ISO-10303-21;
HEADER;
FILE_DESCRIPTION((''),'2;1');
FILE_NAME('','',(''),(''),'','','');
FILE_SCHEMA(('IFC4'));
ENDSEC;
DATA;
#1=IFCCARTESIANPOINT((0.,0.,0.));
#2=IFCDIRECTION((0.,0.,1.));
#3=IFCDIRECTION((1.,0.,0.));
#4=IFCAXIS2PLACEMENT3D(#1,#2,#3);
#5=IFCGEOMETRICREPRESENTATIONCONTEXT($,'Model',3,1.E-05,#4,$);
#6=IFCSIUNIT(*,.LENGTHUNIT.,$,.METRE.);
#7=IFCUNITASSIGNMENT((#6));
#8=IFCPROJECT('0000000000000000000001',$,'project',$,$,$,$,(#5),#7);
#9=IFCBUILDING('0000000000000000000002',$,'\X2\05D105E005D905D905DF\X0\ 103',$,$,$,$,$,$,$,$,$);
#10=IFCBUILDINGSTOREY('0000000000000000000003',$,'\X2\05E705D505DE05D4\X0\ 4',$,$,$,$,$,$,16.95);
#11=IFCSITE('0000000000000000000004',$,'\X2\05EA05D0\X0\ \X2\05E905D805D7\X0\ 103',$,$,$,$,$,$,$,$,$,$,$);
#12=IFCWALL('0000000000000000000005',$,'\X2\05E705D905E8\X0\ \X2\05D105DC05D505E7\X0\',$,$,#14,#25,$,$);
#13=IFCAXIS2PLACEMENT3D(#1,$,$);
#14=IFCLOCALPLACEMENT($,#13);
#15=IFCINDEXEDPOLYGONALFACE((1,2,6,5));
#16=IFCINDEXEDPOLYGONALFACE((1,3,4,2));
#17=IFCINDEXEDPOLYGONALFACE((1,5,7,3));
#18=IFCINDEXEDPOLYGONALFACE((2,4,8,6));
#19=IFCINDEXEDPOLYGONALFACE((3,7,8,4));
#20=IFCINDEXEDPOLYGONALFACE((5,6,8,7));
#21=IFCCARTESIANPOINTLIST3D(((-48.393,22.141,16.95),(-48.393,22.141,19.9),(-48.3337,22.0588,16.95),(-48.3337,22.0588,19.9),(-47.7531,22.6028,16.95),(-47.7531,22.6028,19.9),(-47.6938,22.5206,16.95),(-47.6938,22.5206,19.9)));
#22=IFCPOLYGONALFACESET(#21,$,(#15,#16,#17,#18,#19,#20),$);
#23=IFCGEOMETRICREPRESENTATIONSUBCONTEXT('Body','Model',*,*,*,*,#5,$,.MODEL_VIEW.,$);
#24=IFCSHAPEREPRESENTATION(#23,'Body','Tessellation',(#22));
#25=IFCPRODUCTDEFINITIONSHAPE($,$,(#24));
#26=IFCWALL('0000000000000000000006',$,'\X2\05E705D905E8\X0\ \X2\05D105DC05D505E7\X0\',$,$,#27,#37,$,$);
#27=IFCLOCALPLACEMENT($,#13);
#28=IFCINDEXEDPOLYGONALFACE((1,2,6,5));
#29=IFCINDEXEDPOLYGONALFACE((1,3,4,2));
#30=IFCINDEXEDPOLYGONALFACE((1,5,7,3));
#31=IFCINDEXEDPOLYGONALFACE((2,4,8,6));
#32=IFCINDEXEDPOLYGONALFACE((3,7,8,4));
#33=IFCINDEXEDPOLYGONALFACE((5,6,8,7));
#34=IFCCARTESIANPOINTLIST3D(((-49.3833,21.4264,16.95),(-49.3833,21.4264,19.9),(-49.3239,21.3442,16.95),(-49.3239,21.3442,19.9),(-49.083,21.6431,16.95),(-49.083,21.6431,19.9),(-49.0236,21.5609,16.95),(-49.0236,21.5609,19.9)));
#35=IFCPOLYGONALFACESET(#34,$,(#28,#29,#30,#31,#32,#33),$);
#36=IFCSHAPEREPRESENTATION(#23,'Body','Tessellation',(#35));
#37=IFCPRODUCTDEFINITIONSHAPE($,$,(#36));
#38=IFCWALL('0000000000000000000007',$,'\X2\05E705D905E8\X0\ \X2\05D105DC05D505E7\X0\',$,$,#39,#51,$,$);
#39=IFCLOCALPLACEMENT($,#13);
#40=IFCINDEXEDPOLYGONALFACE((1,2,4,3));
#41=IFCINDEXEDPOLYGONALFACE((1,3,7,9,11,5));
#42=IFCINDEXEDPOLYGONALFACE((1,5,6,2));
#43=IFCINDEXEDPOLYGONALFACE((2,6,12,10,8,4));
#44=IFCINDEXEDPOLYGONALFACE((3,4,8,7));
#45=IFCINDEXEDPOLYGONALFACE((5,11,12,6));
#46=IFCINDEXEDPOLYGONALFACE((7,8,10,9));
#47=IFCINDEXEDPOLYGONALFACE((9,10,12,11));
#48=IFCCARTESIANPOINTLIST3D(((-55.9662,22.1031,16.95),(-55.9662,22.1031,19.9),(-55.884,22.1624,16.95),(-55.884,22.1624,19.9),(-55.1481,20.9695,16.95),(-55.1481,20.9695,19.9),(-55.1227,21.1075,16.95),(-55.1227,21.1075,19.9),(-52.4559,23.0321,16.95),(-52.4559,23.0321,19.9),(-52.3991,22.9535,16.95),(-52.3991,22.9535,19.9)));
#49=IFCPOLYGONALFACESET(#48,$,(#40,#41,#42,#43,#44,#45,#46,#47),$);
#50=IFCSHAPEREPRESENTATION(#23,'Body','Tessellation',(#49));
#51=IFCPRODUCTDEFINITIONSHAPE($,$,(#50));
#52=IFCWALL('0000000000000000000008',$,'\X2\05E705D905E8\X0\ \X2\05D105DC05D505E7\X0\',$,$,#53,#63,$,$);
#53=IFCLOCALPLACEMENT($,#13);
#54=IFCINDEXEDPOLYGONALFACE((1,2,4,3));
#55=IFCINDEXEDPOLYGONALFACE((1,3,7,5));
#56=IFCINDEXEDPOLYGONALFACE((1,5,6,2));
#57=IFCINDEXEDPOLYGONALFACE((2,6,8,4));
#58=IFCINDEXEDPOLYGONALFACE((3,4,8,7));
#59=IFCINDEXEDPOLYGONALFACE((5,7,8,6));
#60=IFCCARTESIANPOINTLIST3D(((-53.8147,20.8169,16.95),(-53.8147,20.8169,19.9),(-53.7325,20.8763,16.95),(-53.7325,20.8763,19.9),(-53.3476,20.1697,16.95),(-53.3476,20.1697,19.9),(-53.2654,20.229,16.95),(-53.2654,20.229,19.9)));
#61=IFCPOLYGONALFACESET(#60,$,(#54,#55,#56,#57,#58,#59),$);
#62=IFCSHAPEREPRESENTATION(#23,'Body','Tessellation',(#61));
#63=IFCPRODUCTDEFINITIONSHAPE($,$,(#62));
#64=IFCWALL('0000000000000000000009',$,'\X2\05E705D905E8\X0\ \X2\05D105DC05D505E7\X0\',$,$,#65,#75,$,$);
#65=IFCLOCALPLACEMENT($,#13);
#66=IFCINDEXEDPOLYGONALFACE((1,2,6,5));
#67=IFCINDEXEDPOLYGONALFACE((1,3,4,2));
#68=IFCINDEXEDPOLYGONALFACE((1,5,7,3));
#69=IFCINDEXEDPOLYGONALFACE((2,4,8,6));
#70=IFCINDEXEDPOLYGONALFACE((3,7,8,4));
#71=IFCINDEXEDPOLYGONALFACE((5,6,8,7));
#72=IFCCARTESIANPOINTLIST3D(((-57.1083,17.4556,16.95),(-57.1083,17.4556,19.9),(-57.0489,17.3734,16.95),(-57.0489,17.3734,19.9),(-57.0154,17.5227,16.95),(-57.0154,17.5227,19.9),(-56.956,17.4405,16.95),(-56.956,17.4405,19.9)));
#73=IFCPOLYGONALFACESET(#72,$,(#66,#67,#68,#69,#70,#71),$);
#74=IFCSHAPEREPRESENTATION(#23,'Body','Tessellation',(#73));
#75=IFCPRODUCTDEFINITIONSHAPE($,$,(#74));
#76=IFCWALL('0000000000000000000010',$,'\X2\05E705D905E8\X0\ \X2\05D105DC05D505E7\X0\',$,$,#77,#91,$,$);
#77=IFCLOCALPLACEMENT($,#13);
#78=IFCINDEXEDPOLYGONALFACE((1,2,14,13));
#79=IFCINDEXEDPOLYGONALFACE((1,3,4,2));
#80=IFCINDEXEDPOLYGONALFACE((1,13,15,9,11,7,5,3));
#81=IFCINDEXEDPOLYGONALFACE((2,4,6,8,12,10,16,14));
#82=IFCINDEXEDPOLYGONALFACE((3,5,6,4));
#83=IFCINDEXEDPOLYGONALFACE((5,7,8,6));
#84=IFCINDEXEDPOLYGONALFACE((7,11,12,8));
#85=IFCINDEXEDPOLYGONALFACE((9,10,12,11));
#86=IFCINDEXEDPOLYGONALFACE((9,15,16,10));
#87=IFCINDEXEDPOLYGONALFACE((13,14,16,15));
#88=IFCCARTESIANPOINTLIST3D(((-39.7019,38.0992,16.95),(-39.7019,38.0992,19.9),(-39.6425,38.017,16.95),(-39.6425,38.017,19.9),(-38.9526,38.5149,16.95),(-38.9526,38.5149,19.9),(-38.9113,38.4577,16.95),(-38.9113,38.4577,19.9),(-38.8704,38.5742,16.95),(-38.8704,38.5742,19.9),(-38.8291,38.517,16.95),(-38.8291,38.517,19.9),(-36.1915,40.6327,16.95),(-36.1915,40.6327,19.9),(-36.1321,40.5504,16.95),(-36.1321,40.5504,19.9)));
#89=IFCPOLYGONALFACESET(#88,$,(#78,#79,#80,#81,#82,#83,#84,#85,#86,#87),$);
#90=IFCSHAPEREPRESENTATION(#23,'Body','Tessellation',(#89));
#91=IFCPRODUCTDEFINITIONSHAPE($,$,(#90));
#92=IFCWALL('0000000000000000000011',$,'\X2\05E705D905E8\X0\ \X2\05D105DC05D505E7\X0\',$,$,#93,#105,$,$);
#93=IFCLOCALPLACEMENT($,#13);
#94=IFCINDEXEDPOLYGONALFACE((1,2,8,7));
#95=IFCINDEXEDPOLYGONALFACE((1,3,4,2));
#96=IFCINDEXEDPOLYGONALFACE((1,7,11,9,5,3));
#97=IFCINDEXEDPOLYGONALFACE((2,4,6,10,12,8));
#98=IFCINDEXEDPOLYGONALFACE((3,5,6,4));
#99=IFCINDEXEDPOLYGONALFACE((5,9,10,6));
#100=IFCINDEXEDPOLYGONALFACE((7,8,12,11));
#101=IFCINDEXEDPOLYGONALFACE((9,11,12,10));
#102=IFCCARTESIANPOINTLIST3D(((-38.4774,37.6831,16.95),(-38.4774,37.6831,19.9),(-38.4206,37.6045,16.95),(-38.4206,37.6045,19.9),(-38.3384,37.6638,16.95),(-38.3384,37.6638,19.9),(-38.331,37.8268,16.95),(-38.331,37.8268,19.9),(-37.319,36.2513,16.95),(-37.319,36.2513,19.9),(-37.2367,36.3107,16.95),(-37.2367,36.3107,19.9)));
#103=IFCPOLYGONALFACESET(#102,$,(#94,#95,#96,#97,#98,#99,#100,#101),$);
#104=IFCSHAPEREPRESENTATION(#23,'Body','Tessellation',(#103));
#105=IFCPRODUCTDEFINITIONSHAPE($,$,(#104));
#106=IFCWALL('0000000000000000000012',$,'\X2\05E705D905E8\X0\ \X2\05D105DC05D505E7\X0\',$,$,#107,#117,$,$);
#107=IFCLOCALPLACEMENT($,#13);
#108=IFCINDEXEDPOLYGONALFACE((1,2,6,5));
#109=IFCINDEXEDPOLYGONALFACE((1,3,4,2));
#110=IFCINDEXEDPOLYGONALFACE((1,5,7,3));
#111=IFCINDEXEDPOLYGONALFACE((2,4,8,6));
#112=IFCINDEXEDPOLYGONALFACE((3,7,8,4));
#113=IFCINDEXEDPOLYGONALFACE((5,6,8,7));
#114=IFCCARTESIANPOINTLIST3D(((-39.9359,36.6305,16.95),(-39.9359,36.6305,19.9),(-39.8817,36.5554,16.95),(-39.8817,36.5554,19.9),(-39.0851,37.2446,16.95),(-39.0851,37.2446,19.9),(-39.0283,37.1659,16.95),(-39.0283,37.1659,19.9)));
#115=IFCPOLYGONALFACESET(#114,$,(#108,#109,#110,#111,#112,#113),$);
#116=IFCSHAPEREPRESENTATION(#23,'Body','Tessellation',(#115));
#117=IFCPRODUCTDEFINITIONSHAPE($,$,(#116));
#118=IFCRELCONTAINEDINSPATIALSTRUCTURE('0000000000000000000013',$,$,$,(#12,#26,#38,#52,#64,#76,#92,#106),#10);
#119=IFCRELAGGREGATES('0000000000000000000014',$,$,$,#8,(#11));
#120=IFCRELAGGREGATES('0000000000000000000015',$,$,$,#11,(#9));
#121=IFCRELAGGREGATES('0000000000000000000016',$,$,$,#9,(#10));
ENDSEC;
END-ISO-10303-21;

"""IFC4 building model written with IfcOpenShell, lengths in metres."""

from ifc_helpers import new_model, si_unit, frame, origin_with_axes, context, subcontext, project, spatial, polyline, outline, extrude, element, save


model = new_model("IFC4")

# Units and contexts
model_context = context("Model", 3, precision=1e-05, world=origin_with_axes())
body_context = subcontext(model_context, "Body", "Model", "MODEL_VIEW")
ifc_project = project(units=[si_unit("LENGTHUNIT", "METRE")], contexts=[model_context])

# Site, building, storey
site = spatial("IfcSite", under=ifc_project, Name="תא שטח 103")
building = spatial("IfcBuilding", under=site, Name="בניין 103")
storey = spatial("IfcBuildingStorey", under=building, Name="קומה 4", Elevation=16.95)

# Walls
element("IfcWall", 1, inside=storey, Name="קיר בלוק", context=body_context, shape_type="SweptSolid", body=[
    extrude(outline(polyline([(-48.3337, 22.0588), (-48.393, 22.141), (-47.7531, 22.6028), (-47.6938, 22.5206), (-48.3337, 22.0588)])), frame((0.0, 0.0, 16.95)), (0.0, 0.0, 1.0), 2.95),
])
element("IfcWall", 2, inside=storey, Name="קיר בלוק", context=body_context, shape_type="SweptSolid", body=[
    extrude(outline(polyline([(-49.3239, 21.3442), (-49.3833, 21.4264), (-49.083, 21.6431), (-49.0236, 21.5609), (-49.3239, 21.3442)])), frame((0.0, 0.0, 16.95)), (0.0, 0.0, 1.0), 2.95),
])
element("IfcWall", 3, inside=storey, Name="קיר בלוק", context=body_context, shape_type="SweptSolid", body=[
    extrude(outline(polyline([(-55.1227, 21.1075), (-52.4559, 23.0321), (-52.3991, 22.9535), (-55.1481, 20.9695), (-55.9662, 22.1031), (-55.884, 22.1624), (-55.1227, 21.1075)])), frame((0.0, 0.0, 16.95)), (0.0, 0.0, 1.0), 2.95),
])
element("IfcWall", 4, inside=storey, Name="קיר בלוק", context=body_context, shape_type="SweptSolid", body=[
    extrude(outline(polyline([(-53.8147, 20.8169), (-53.7325, 20.8763), (-53.2654, 20.229), (-53.3476, 20.1697), (-53.8147, 20.8169)])), frame((0.0, 0.0, 16.95)), (0.0, 0.0, 1.0), 2.95),
])
element("IfcWall", 5, inside=storey, Name="קיר בלוק", context=body_context, shape_type="SweptSolid", body=[
    extrude(outline(polyline([(-57.0154, 17.5227), (-56.956, 17.4405), (-57.0489, 17.3734), (-57.1083, 17.4556), (-57.0154, 17.5227)])), frame((0.0, 0.0, 16.95)), (0.0, 0.0, 1.0), 2.95),
])
element("IfcWall", 6, inside=storey, Name="קיר בלוק", context=body_context, shape_type="SweptSolid", body=[
    extrude(outline(polyline([(-39.6425, 38.017), (-39.7019, 38.0992), (-36.1915, 40.6327), (-36.1321, 40.5504), (-38.8704, 38.5742), (-38.8291, 38.517), (-38.9113, 38.4577), (-38.9526, 38.5149), (-39.6425, 38.017)])), frame((0.0, 0.0, 16.95)), (0.0, 0.0, 1.0), 2.95),
])
element("IfcWall", 7, inside=storey, Name="קיר בלוק", context=body_context, shape_type="SweptSolid", body=[
    extrude(outline(polyline([(-38.4206, 37.6045), (-38.4774, 37.6831), (-38.331, 37.8268), (-37.2367, 36.3107), (-37.319, 36.2513), (-38.3384, 37.6638), (-38.4206, 37.6045)])), frame((0.0, 0.0, 16.95)), (0.0, 0.0, 1.0), 2.95),
])
element("IfcWall", 8, inside=storey, Name="קיר בלוק", context=body_context, shape_type="SweptSolid", body=[
    extrude(outline(polyline([(-39.9359, 36.6305), (-39.0851, 37.2446), (-39.0283, 37.1659), (-39.8817, 36.5554), (-39.9359, 36.6305)])), frame((0.0, 0.0, 16.95)), (0.0, 0.0, 1.0), 2.95),
])

save(model, "model.ifc")
